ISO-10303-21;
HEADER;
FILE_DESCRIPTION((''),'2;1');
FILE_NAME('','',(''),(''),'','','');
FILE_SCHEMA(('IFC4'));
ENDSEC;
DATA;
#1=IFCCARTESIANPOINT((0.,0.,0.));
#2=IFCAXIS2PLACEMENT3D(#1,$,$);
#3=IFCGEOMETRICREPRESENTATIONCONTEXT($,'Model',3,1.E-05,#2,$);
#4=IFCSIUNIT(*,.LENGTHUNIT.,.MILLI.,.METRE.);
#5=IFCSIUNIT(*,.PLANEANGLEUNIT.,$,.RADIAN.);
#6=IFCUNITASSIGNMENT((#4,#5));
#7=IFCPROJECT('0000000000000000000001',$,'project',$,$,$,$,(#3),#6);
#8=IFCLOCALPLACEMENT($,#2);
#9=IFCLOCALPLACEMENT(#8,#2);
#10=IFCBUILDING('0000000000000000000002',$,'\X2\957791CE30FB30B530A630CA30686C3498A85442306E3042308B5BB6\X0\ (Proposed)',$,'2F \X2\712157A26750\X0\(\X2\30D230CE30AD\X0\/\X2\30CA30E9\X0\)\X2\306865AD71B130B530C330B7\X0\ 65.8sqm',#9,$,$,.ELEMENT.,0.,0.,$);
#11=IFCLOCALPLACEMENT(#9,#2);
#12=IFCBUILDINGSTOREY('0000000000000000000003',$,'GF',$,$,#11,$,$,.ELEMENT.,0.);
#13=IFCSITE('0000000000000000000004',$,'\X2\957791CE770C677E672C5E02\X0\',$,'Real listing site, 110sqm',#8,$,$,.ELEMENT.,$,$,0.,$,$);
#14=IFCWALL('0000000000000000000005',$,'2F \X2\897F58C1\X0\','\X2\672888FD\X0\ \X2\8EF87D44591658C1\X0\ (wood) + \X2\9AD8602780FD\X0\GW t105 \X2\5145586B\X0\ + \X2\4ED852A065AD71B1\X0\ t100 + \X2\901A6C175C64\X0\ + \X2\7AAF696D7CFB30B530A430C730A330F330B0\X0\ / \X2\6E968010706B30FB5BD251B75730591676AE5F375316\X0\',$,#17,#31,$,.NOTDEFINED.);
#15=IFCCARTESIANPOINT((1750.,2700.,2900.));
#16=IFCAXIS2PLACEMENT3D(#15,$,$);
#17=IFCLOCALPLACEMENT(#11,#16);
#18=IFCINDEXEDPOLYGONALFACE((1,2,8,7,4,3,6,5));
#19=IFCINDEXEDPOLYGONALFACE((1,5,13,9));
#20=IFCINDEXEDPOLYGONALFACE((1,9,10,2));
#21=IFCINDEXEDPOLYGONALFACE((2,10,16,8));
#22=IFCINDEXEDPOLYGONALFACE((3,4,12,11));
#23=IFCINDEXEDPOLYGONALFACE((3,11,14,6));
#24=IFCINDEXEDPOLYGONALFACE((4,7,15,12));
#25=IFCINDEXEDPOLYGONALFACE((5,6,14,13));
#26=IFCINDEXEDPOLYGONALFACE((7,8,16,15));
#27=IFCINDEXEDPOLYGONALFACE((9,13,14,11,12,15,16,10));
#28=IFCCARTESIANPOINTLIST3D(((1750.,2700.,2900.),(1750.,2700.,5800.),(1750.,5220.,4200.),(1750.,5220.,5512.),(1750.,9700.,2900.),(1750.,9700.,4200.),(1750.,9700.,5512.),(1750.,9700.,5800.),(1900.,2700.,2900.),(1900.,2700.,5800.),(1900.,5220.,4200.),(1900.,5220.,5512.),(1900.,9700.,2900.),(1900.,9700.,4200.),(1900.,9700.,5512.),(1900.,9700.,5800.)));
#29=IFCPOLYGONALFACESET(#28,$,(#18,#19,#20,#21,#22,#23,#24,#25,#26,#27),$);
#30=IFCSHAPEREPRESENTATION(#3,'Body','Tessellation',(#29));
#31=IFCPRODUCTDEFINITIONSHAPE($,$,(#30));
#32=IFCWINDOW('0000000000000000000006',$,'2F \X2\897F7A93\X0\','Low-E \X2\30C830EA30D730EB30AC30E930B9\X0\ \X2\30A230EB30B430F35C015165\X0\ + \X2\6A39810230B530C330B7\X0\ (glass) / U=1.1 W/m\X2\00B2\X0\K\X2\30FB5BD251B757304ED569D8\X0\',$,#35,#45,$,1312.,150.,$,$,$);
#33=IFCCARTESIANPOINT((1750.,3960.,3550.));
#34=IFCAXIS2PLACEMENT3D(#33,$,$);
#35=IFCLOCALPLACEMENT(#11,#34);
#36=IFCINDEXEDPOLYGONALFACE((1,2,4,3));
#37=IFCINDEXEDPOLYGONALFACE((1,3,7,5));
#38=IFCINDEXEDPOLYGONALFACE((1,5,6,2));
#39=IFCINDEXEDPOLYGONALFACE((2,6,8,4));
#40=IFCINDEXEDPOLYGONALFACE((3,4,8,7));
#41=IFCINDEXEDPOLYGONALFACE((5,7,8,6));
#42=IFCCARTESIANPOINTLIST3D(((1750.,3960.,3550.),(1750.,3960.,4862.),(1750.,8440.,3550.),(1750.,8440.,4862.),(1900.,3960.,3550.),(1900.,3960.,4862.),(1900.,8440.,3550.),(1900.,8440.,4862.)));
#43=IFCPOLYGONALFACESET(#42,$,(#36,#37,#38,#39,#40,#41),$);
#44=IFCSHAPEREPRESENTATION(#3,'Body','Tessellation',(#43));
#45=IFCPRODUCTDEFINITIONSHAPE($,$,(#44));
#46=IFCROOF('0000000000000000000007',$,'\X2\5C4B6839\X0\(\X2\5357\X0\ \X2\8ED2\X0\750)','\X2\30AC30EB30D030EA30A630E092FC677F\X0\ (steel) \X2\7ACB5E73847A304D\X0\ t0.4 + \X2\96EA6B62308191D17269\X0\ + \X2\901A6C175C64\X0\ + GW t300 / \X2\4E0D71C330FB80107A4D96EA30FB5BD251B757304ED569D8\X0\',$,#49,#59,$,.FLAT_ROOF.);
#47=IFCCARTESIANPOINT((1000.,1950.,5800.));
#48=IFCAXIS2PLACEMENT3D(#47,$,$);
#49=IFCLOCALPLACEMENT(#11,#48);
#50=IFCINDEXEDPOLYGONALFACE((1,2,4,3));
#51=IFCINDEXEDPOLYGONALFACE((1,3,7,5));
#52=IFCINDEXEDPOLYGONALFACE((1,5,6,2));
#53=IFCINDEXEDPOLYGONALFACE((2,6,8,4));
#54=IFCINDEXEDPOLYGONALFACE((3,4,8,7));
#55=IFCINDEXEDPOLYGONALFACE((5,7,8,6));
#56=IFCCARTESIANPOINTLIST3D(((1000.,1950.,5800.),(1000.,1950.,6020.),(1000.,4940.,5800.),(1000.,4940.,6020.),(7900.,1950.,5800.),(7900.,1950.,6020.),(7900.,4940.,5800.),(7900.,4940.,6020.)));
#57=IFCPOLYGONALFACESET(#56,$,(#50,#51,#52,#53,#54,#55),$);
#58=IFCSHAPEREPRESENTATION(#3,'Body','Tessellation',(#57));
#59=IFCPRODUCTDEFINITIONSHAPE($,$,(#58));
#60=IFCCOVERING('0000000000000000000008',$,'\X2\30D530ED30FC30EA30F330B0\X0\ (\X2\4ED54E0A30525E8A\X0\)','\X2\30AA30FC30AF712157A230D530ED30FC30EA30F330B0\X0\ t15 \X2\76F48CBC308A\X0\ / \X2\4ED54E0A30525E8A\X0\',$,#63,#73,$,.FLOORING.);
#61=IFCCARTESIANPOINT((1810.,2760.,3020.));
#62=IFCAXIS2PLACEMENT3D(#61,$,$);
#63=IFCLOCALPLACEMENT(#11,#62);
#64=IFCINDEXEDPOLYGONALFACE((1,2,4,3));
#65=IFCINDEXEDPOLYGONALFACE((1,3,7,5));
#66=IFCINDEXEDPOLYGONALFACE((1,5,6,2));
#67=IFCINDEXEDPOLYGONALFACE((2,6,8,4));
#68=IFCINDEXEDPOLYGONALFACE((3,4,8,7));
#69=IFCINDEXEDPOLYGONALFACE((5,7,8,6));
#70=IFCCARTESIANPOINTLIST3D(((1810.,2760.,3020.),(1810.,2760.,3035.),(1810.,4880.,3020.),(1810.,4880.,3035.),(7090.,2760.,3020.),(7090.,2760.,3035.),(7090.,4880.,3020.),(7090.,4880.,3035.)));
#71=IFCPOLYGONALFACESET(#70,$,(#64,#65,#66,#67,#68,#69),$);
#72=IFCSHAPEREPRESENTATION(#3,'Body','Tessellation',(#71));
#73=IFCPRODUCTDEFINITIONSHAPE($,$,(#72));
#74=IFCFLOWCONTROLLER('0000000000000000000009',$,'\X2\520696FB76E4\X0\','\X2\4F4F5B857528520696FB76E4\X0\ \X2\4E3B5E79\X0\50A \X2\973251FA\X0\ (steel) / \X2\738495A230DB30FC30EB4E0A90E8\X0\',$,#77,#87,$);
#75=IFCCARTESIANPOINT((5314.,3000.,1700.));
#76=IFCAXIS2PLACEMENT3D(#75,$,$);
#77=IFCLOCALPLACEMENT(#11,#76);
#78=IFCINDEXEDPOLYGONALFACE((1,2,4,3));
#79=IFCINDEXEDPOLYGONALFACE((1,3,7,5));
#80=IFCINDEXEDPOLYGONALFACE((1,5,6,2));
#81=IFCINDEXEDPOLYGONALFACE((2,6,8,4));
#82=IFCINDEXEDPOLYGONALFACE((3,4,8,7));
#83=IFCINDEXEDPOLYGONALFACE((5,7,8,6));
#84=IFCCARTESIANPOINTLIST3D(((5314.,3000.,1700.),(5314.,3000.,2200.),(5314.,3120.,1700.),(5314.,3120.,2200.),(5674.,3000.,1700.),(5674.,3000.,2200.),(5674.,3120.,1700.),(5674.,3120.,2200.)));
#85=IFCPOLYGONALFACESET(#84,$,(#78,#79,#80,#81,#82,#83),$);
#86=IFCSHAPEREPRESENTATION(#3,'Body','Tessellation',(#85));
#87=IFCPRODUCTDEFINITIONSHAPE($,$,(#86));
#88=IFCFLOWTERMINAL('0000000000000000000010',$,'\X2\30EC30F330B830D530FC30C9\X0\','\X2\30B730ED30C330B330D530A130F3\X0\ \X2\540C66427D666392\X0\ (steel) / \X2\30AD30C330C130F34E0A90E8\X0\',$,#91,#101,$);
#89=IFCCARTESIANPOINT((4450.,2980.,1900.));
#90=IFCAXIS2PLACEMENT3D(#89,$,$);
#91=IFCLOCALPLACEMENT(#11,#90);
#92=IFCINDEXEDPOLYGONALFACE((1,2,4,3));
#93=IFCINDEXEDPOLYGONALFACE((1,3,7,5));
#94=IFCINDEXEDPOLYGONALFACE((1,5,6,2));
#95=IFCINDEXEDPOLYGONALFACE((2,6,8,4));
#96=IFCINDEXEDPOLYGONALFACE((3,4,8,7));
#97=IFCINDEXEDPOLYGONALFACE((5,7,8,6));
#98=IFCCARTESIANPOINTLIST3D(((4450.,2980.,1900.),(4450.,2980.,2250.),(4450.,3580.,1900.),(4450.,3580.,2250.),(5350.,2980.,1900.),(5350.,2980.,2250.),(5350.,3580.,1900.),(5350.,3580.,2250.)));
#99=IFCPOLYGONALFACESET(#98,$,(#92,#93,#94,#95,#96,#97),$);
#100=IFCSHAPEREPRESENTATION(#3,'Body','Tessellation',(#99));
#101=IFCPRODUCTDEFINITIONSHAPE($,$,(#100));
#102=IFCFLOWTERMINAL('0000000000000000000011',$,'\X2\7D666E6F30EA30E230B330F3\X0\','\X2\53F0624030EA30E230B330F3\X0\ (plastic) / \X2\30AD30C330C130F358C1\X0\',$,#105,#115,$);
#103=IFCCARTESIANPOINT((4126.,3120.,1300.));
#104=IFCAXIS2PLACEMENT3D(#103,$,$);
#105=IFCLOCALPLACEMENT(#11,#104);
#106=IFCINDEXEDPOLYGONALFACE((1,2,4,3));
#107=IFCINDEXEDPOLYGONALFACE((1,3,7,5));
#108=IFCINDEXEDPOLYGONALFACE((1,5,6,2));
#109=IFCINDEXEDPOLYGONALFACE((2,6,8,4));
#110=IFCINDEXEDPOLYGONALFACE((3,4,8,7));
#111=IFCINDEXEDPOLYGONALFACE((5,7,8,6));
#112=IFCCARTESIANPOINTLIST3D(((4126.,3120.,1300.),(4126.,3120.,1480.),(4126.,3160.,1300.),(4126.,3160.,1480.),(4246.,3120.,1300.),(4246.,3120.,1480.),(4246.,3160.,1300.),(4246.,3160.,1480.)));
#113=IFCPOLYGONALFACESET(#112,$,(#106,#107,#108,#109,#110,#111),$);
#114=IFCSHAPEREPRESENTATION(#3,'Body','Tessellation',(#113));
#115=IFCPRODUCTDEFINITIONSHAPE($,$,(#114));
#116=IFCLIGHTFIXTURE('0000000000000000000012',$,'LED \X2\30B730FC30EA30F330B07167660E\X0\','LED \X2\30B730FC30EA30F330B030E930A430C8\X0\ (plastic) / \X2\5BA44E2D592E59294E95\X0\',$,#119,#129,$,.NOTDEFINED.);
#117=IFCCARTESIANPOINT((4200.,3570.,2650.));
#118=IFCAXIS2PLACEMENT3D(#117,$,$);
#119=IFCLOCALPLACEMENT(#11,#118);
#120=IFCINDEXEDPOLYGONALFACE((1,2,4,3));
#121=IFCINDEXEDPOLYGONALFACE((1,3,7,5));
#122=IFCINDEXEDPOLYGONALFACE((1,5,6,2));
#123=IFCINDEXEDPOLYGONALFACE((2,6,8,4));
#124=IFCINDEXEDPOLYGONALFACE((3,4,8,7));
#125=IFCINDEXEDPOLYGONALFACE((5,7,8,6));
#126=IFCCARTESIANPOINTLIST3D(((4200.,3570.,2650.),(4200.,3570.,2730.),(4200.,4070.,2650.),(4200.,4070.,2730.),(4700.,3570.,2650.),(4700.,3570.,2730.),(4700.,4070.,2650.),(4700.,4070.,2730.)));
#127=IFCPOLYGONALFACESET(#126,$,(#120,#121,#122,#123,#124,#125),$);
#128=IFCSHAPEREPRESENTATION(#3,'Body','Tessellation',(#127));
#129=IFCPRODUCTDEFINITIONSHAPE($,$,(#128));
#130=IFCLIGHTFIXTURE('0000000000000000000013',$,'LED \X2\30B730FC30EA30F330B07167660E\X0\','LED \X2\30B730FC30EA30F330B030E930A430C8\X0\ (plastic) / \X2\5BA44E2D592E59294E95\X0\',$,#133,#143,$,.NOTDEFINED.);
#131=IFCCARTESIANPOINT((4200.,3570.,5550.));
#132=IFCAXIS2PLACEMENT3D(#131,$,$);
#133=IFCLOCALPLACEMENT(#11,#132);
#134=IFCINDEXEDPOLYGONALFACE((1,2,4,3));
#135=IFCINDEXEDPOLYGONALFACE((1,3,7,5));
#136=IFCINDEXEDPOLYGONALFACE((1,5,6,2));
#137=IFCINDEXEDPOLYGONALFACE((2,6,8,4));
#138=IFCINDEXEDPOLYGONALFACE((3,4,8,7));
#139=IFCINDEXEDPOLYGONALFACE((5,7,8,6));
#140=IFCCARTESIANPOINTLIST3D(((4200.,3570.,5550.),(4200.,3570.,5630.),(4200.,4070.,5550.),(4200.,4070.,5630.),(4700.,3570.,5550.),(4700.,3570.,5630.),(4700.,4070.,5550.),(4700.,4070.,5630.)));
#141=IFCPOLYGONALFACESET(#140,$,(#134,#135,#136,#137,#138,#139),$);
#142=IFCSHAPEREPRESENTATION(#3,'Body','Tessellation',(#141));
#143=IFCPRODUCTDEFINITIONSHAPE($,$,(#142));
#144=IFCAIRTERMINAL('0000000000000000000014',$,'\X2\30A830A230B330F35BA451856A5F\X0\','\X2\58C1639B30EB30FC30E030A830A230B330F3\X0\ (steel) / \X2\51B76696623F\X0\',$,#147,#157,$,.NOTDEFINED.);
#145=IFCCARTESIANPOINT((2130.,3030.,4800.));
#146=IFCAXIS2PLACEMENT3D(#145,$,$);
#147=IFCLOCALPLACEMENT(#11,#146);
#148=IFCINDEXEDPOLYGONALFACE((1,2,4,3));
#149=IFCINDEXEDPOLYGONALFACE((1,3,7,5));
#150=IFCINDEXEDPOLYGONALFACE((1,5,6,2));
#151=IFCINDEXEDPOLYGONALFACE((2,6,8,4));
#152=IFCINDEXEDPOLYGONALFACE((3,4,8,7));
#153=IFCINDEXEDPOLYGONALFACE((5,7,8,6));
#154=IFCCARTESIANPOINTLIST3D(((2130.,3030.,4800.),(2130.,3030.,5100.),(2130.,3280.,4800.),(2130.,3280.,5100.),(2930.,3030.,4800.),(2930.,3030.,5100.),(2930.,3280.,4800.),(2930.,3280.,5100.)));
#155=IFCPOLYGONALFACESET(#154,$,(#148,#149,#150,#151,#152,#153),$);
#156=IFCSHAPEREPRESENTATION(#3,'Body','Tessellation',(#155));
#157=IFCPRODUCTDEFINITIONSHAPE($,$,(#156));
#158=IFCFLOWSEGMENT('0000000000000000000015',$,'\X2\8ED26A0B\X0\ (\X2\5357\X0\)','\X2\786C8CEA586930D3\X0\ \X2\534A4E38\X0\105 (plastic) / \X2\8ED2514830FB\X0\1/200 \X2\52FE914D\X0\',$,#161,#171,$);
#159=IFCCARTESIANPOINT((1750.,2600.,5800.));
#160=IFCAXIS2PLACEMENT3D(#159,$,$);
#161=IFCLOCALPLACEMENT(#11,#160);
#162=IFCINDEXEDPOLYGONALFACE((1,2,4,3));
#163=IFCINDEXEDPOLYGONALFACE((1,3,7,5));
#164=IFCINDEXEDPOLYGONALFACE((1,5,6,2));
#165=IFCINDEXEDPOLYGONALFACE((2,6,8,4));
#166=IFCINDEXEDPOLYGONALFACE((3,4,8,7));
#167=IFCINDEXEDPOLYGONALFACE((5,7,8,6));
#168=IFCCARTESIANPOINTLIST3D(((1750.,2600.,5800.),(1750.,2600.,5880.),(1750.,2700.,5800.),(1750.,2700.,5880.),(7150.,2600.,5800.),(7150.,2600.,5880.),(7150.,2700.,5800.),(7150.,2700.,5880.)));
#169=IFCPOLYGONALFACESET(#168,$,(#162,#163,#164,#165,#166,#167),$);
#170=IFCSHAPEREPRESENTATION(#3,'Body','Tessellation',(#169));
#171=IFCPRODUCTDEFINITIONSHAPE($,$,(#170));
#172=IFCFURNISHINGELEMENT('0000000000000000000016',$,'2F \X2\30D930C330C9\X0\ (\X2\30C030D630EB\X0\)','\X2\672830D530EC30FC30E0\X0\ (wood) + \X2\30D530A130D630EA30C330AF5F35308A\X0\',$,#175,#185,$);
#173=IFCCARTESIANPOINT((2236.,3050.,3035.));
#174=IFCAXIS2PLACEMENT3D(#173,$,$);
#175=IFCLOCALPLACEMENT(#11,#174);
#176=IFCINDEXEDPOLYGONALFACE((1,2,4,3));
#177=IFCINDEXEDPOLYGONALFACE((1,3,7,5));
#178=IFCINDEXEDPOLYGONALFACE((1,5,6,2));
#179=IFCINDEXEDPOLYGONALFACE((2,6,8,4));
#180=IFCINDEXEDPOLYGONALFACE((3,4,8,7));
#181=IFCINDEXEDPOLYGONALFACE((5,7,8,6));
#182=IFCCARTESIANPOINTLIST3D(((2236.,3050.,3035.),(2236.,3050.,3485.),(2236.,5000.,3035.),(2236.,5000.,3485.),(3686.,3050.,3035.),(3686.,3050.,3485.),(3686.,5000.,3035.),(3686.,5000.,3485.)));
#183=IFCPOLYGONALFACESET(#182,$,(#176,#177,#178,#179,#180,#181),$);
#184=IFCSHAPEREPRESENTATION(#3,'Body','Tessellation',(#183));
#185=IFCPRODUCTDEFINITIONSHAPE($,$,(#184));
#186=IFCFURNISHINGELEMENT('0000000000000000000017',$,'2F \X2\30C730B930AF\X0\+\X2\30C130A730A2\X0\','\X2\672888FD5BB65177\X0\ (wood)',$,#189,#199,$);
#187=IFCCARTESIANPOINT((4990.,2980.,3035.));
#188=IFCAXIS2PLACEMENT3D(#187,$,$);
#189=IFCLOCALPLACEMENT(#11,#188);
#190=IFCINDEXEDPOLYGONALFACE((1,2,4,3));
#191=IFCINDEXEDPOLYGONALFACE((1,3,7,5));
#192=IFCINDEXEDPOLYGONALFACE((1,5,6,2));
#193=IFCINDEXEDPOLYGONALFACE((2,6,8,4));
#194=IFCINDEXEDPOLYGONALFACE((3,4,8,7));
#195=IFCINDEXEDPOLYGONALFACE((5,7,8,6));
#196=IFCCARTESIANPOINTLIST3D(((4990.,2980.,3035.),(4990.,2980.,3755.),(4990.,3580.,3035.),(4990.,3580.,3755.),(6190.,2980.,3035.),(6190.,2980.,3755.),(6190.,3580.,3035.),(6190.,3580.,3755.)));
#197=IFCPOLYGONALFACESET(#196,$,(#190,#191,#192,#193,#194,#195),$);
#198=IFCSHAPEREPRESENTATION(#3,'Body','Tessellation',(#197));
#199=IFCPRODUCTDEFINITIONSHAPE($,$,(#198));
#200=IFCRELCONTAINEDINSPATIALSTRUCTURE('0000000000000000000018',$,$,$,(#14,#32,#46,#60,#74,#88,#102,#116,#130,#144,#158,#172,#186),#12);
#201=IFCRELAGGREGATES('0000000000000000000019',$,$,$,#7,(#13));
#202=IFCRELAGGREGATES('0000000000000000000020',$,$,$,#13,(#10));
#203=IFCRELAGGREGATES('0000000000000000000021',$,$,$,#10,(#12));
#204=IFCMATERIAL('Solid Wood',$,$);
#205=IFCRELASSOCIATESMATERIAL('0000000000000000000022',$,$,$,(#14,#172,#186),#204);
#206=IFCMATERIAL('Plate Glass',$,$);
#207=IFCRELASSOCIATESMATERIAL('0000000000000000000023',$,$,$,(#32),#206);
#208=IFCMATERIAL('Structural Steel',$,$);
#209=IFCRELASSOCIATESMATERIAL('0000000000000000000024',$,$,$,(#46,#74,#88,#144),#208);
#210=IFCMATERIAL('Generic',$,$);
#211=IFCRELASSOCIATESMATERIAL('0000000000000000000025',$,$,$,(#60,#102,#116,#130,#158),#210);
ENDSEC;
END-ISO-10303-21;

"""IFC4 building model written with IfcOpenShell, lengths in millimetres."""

from ifc_helpers import new_model, si_unit, frame, frame_2d, origin, place, context, project, spatial, rectangle, extrude, material, element, fill, save


model = new_model("IFC4")

# Units and contexts
model_context = context("Model", 3, precision=1e-05, world=origin())
ifc_project = project(units=[si_unit("LENGTHUNIT", "METRE", prefix="MILLI"), si_unit("PLANEANGLEUNIT", "RADIAN")], contexts=[model_context])

# Site, building, storey
site_placement = place(None, origin())
site = spatial("IfcSite", under=ifc_project, at=site_placement, Name="長野県松本市", ObjectType="Real listing site, 110sqm", CompositionType="ELEMENT", RefElevation=0.0)
building_placement = place(site_placement, origin())
building = spatial("IfcBuilding", under=site, at=building_placement, Name="長野・サウナと水風呂のある家 (Proposed)", ObjectType="2F 無垢材(ヒノキ/ナラ)と断熱サッシ 65.8sqm", CompositionType="ELEMENT", ElevationOfRefHeight=0.0, ElevationOfTerrain=0.0)
storey_placement = place(building_placement, origin())
storey = spatial("IfcBuildingStorey", under=building, at=storey_placement, Name="GF", CompositionType="ELEMENT", Elevation=0.0)

# Shared definitions
ifc_material_1 = material(Name="Solid Wood")

# Wall, opening, window
ifc_material_2 = material(Name="Plate Glass")
wall_1_placement = place(storey_placement, frame((1750.0, 2700.0, 2900.0)))
wall_1 = element("IfcWall", 1, at=wall_1_placement, inside=storey, material=ifc_material_1, Name="2F 西壁", Description="木製 軸組外壁 (wood) + 高性能GW t105 充填 + 付加断熱 t100 + 通気層 + 窯業系サイディング / 準耐火・寒冷地外皮強化", PredefinedType="NOTDEFINED", context=model_context, shape_type="SweptSolid", body=[
    extrude(rectangle(XDim=150.0, YDim=7000.0, at=frame_2d((75.0, 3500.0))), frame((1750.0, 2700.0, 2900.0)), (0.0, 0.0, 1.0), 2900.0),
])
opening_1_placement = place(storey_placement, frame((1750.0, 3960.0, 3550.0)))
opening_1 = element("IfcOpeningElement", 2, at=opening_1_placement, cuts=wall_1, PredefinedType="NOTDEFINED", context=model_context, shape_type="SweptSolid", body=[
    extrude(rectangle(XDim=150.0, YDim=4480.0, at=frame_2d((75.0, 2240.0))), frame((1750.0, 3960.0, 3550.0)), (0.0, 0.0, 1.0), 1312.0),
])
window_1_placement = place(storey_placement, frame((1750.0, 3960.0, 3550.0)))
window_1 = element("IfcWindow", 3, at=window_1_placement, inside=storey, material=ifc_material_2, Name="2F 西窓", Description="Low-E トリプルガラス アルゴン封入 + 樹脂サッシ (glass) / U=1.1 W/m²K・寒冷地仕様", OverallHeight=1312.0, OverallWidth=150.0, context=model_context, shape_type="SweptSolid", body=[
    extrude(rectangle(XDim=150.0, YDim=4480.0, at=frame_2d((75.0, 2240.0))), frame((1750.0, 3960.0, 3550.0)), (0.0, 0.0, 1.0), 1312.0),
])
fill(opening_1, window_1)

# Roof
ifc_material_3 = material(Name="Structural Steel")
for number, where, name in (
    (4, (1000.0, 1950.0, 5800.0), "屋根(南 軒750)"),
):
    element("IfcRoof", number, at=place(storey_placement, frame(where)), inside=storey, material=ifc_material_3, Name=name, Description="ガルバリウム鋼板 (steel) 立平葺き t0.4 + 雪止め金物 + 通気層 + GW t300 / 不燃・耐積雪・寒冷地仕様", PredefinedType="FLAT_ROOF", context=model_context, shape_type="SweptSolid", body=[
        extrude(rectangle(XDim=6900.0, YDim=2990.0, at=frame_2d((3450.0, 1495.0))), frame((1000.0, 1950.0, 5800.0)), (0.0, 0.0, 1.0), 220.0),
    ])

# Covering
ifc_material_4 = material(Name="Generic")
covering_placement = place(storey_placement, frame((1810.0, 2760.0, 3020.0)))
element("IfcCovering", 5, at=covering_placement, inside=storey, material=ifc_material_4, Name="フローリング (仕上げ床)", Description="オーク無垢フローリング t15 直貼り / 仕上げ床", PredefinedType="FLOORING", context=model_context, shape_type="SweptSolid", body=[
    extrude(rectangle(XDim=5280.0, YDim=2120.0, at=frame_2d((2640.0, 1060.0))), frame((1810.0, 2760.0, 3020.0)), (0.0, 0.0, 1.0), 15.0),
])

# Flow controller
flow_controller_placement = place(storey_placement, frame((5314.0, 3000.0, 1700.0)))
element("IfcFlowController", 6, at=flow_controller_placement, inside=storey, material=ifc_material_3, Name="分電盤", Description="住宅用分電盤 主幹50A 露出 (steel) / 玄関ホール上部", context=model_context, shape_type="SweptSolid", body=[
    extrude(rectangle(XDim=360.0, YDim=120.0, at=frame_2d((180.0, 60.0))), frame((5314.0, 3000.0, 1700.0)), (0.0, 0.0, 1.0), 500.0),
])

# Flow terminals
flow_terminal_1_placement = place(storey_placement, frame((4450.0, 2980.0, 1900.0)))
element("IfcFlowTerminal", 7, at=flow_terminal_1_placement, inside=storey, material=ifc_material_3, Name="レンジフード", Description="シロッコファン 同時給排 (steel) / キッチン上部", context=model_context, shape_type="SweptSolid", body=[
    extrude(rectangle(XDim=900.0, YDim=600.0, at=frame_2d((450.0, 300.0))), frame((4450.0, 2980.0, 1900.0)), (0.0, 0.0, 1.0), 350.0),
])
flow_terminal_2_placement = place(storey_placement, frame((4126.0, 3120.0, 1300.0)))
element("IfcFlowTerminal", 8, at=flow_terminal_2_placement, inside=storey, material=ifc_material_4, Name="給湯リモコン", Description="台所リモコン (plastic) / キッチン壁", context=model_context, shape_type="SweptSolid", body=[
    extrude(rectangle(XDim=120.0, YDim=40.0, at=frame_2d((60.0, 20.0))), frame((4126.0, 3120.0, 1300.0)), (0.0, 0.0, 1.0), 180.0),
])

# Light fixtures
light_fixture_1_placement = place(storey_placement, frame((4200.0, 3570.0, 2650.0)))
element("IfcLightFixture", 9, at=light_fixture_1_placement, inside=storey, material=ifc_material_4, Name="LED シーリング照明", Description="LED シーリングライト (plastic) / 室中央天井", PredefinedType="NOTDEFINED", context=model_context, shape_type="SweptSolid", body=[
    extrude(rectangle(XDim=500.0, YDim=500.0, at=frame_2d((250.0, 250.0))), frame((4200.0, 3570.0, 2650.0)), (0.0, 0.0, 1.0), 80.0),
])
light_fixture_2_placement = place(storey_placement, frame((4200.0, 3570.0, 5550.0)))
element("IfcLightFixture", 10, at=light_fixture_2_placement, inside=storey, material=ifc_material_4, Name="LED シーリング照明", Description="LED シーリングライト (plastic) / 室中央天井", PredefinedType="NOTDEFINED", context=model_context, shape_type="SweptSolid", body=[
    extrude(rectangle(XDim=500.0, YDim=500.0, at=frame_2d((250.0, 250.0))), frame((4200.0, 3570.0, 5550.0)), (0.0, 0.0, 1.0), 80.0),
])

# Air terminal
air_terminal_placement = place(storey_placement, frame((2130.0, 3030.0, 4800.0)))
element("IfcAirTerminal", 11, at=air_terminal_placement, inside=storey, material=ifc_material_3, Name="エアコン室内機", Description="壁掛ルームエアコン (steel) / 冷暖房", PredefinedType="NOTDEFINED", context=model_context, shape_type="SweptSolid", body=[
    extrude(rectangle(XDim=800.0, YDim=250.0, at=frame_2d((400.0, 125.0))), frame((2130.0, 3030.0, 4800.0)), (0.0, 0.0, 1.0), 300.0),
])

# Flow segment
flow_segment_placement = place(storey_placement, frame((1750.0, 2600.0, 5800.0)))
element("IfcFlowSegment", 12, at=flow_segment_placement, inside=storey, material=ifc_material_4, Name="軒樋 (南)", Description="硬質塩ビ 半丸105 (plastic) / 軒先・1/200 勾配", context=model_context, shape_type="SweptSolid", body=[
    extrude(rectangle(XDim=5400.0, YDim=100.0, at=frame_2d((2700.0, 50.0))), frame((1750.0, 2600.0, 5800.0)), (0.0, 0.0, 1.0), 80.0),
])

# Furnishing elements
furnishing_1_placement = place(storey_placement, frame((2236.0, 3050.0, 3035.0)))
element("IfcFurnishingElement", 13, at=furnishing_1_placement, inside=storey, material=ifc_material_1, Name="2F ベッド (ダブル)", Description="木フレーム (wood) + ファブリック張り", context=model_context, shape_type="SweptSolid", body=[
    extrude(rectangle(XDim=1450.0, YDim=1950.0, at=frame_2d((725.0, 975.0))), frame((2236.0, 3050.0, 3035.0)), (0.0, 0.0, 1.0), 450.0),
])
furnishing_2_placement = place(storey_placement, frame((4990.0, 2980.0, 3035.0)))
element("IfcFurnishingElement", 14, at=furnishing_2_placement, inside=storey, material=ifc_material_1, Name="2F デスク+チェア", Description="木製家具 (wood)", context=model_context, shape_type="SweptSolid", body=[
    extrude(rectangle(XDim=1200.0, YDim=600.0, at=frame_2d((600.0, 300.0))), frame((4990.0, 2980.0, 3035.0)), (0.0, 0.0, 1.0), 720.0),
])

save(model, "model.ifc")
